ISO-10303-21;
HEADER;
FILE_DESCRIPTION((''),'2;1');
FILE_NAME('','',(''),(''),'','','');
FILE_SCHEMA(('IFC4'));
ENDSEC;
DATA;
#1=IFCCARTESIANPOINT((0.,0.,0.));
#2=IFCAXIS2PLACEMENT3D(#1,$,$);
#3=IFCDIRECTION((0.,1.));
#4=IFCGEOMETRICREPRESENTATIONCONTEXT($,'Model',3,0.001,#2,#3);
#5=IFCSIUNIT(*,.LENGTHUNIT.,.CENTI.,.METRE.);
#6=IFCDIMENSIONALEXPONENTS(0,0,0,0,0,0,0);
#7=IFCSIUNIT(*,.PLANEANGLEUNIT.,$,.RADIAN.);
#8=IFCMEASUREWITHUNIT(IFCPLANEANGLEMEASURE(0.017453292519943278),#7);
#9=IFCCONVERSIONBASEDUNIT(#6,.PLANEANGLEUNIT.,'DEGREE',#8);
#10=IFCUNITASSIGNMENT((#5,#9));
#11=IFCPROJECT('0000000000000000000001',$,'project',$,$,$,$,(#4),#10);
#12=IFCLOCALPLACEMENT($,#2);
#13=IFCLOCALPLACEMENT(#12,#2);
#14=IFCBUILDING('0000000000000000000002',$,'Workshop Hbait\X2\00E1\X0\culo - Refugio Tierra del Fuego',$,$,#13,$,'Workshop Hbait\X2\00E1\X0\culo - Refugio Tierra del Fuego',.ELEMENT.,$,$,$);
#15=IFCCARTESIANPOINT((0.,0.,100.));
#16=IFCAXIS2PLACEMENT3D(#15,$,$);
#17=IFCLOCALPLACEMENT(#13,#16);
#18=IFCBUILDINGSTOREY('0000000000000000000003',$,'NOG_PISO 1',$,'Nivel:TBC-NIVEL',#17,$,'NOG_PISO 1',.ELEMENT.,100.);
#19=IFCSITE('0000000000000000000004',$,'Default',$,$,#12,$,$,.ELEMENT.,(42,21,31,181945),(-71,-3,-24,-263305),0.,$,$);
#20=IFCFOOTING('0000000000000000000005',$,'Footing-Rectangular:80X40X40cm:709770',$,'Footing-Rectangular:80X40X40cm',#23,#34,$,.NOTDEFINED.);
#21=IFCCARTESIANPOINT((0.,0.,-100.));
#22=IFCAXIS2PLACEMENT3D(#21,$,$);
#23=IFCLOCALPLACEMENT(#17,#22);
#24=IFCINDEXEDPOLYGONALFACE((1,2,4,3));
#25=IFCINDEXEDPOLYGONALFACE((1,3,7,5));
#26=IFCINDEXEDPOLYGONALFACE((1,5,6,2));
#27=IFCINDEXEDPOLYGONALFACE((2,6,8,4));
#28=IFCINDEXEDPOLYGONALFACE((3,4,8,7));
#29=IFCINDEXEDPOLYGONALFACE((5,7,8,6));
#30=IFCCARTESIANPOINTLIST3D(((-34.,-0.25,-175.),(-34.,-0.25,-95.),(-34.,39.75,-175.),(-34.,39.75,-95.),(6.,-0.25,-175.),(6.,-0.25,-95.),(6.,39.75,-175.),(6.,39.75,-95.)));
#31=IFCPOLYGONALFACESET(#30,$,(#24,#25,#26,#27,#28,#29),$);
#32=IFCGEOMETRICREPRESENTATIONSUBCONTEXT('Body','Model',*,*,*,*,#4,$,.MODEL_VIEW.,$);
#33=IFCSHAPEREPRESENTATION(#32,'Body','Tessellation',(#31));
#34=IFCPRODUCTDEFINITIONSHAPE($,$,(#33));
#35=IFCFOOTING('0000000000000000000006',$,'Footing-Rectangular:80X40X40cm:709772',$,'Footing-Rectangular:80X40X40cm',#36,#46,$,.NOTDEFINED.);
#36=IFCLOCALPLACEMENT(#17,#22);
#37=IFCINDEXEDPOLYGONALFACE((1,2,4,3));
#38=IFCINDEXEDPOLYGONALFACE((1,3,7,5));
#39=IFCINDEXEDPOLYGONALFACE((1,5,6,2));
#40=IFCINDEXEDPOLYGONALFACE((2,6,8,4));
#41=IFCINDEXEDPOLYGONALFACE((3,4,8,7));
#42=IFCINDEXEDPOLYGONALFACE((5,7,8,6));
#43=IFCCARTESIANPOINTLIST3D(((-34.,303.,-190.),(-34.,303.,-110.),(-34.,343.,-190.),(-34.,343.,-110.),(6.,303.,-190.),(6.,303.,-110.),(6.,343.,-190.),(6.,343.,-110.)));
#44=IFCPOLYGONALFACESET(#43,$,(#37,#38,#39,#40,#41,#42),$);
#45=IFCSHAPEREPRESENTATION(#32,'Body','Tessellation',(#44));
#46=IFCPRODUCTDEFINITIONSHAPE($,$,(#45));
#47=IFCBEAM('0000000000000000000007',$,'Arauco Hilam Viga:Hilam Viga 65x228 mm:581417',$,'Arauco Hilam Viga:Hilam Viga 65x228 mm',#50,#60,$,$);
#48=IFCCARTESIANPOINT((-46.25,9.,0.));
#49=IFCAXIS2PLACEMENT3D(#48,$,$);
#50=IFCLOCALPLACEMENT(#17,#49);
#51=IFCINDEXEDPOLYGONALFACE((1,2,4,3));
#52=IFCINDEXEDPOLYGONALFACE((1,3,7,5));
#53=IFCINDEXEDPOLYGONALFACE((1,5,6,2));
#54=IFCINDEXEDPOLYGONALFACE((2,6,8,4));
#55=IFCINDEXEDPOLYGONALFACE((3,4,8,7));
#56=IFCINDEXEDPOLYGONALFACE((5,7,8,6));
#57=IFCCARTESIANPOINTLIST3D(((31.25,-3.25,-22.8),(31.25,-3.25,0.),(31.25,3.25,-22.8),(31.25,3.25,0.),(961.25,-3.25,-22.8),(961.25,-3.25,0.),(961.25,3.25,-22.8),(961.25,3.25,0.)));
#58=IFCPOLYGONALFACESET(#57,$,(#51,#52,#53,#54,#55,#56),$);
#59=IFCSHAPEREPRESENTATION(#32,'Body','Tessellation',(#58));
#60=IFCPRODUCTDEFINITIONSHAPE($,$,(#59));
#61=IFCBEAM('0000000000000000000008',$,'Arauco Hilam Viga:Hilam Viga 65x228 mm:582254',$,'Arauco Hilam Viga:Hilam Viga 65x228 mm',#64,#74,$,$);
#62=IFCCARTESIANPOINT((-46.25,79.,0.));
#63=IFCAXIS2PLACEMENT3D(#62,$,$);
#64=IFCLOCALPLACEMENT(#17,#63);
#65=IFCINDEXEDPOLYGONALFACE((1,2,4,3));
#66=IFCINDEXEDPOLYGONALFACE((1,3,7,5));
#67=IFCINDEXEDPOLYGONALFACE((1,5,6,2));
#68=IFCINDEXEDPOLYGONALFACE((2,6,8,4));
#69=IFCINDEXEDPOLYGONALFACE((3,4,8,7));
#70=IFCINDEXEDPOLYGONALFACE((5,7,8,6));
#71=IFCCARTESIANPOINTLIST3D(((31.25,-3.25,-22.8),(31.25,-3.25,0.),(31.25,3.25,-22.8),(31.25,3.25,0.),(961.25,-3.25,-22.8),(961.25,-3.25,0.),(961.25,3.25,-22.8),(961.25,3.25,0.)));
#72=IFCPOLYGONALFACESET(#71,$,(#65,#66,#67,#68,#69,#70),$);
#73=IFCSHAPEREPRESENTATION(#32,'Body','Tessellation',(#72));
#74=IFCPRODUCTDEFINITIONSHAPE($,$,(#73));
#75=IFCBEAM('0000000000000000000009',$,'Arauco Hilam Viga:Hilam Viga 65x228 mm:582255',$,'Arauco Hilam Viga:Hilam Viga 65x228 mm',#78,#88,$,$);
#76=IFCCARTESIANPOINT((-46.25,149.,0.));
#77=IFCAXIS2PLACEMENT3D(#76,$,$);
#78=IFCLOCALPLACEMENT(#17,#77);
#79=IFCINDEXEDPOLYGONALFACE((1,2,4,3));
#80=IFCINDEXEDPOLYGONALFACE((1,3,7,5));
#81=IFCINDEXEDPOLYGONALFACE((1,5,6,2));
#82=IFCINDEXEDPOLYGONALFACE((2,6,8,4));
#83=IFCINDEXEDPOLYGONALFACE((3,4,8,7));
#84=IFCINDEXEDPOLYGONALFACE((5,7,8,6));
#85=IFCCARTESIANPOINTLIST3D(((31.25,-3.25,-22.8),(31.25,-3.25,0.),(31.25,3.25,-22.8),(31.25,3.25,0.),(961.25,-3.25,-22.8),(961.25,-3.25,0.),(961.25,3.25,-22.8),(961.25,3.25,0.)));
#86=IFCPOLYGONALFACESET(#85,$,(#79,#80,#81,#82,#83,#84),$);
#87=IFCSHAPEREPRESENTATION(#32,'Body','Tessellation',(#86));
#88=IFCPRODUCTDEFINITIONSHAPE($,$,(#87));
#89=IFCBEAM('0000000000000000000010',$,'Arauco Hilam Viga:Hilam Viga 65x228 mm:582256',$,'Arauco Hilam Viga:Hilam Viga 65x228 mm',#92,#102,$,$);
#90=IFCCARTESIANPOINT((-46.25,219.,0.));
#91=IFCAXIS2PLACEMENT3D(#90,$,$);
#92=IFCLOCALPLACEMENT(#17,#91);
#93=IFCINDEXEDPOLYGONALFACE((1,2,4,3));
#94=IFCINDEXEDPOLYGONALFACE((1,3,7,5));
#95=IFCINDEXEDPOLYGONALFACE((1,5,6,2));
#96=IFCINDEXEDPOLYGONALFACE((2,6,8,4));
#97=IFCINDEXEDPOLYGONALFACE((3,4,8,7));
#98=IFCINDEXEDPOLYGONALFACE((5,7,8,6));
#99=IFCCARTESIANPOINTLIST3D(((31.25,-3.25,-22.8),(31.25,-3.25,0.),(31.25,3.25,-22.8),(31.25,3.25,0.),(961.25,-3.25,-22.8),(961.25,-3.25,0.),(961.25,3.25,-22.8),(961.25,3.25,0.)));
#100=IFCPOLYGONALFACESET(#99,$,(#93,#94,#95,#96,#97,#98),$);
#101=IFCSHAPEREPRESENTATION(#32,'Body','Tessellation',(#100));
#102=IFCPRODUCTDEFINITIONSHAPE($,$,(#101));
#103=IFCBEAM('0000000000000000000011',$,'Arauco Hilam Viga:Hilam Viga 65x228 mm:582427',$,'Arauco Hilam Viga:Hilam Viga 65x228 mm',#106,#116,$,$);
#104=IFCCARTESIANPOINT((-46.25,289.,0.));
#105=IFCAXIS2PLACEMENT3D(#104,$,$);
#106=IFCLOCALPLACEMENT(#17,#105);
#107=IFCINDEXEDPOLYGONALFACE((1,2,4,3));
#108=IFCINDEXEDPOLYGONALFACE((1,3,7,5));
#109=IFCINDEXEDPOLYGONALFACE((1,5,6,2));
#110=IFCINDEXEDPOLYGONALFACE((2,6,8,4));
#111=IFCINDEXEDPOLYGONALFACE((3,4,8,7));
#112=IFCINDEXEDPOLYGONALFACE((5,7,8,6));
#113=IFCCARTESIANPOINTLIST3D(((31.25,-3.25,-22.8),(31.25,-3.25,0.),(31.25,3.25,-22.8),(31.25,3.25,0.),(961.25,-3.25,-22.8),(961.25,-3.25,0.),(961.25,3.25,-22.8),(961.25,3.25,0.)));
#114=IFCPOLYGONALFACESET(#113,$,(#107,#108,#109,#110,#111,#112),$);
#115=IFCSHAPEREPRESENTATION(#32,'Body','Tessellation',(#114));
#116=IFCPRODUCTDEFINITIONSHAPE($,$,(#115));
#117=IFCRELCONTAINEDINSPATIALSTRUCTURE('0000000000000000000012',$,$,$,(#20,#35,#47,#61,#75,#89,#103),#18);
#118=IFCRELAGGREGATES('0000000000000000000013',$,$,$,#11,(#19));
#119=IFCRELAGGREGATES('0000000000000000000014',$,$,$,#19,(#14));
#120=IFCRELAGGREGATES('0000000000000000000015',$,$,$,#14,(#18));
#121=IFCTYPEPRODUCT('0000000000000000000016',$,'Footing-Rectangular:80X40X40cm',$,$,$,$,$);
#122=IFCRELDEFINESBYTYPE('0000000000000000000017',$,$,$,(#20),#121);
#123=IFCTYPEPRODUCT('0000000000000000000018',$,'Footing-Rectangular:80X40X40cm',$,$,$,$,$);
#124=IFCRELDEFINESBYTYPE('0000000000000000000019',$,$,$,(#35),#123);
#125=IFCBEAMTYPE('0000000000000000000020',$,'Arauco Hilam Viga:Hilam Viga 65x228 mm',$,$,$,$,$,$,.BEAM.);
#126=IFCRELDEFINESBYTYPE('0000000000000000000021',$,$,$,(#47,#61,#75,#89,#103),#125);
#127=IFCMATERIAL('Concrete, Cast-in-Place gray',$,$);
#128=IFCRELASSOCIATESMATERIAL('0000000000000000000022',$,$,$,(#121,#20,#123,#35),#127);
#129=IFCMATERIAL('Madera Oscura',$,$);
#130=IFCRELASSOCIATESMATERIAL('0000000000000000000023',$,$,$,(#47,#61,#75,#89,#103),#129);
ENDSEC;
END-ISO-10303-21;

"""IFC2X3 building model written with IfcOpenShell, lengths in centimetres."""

from ifc_helpers import new_model, entity, si_unit, converted_unit, direction, frame, frame_2d, origin, origin_2d_with_axis, place, context, subcontext, project, spatial, rectangle, extrude, source, transform, mapped, material, type_object, type_shapes, element, save


model = new_model("IFC2X3")

# Units and contexts
model_context = context("Model", 3, precision=0.001, world=origin(), true_north=direction((0.0, 1.0)))
body_context = subcontext(model_context, "Body", "Model", "MODEL_VIEW")
ifc_project = project(units=[si_unit("LENGTHUNIT", "METRE", prefix="CENTI"), converted_unit("PLANEANGLEUNIT", "DEGREE", entity("IfcPlaneAngleMeasure", 0.017453292519943278), si_unit("PLANEANGLEUNIT", "RADIAN"), dimensions=[0, 0, 0, 0, 0, 0, 0])], contexts=[model_context])

# Site, building, storey
site_placement = place(None, origin())
site = spatial("IfcSite", under=ifc_project, at=site_placement, Name="Default", CompositionType="ELEMENT", RefLatitude=(42, 21, 31, 181945), RefLongitude=(-71, -3, -24, -263305), RefElevation=0.0)
building_placement = place(site_placement, origin())
building = spatial("IfcBuilding", under=site, at=building_placement, Name="Workshop Hbaitáculo - Refugio Tierra del Fuego", LongName="Workshop Hbaitáculo - Refugio Tierra del Fuego", CompositionType="ELEMENT")
storey_placement = place(building_placement, frame((0.0, 0.0, 100.0)))
storey = spatial("IfcBuildingStorey", under=building, at=storey_placement, Name="NOG_PISO 1", ObjectType="Nivel:TBC-NIVEL", LongName="NOG_PISO 1", CompositionType="ELEMENT", Elevation=100.0)

# Footings
ifc_material_1 = material(Name="Concrete, Cast-in-Place gray")
type_product_1 = type_object("IfcTypeProduct", Name="Footing-Rectangular:80X40X40cm", material=ifc_material_1)
shared_shape_1 = source(origin(), body_context, "Body", "SweptSolid", [
    extrude(rectangle(XDim=40.0, YDim=40.0, at=frame_2d((0.0, 0.0), x_axis=(1.0, 0.0))), frame((-14.0, 19.75, -175.0), z_axis=(0.0, 0.0, 1.0), x_axis=(-1.0, 0.0, 0.0)), (0.0, 0.0, 1.0), 80.0),
])
type_shapes(type_product_1, [shared_shape_1])
footing_1_placement = place(storey_placement, frame((0.0, 0.0, -100.0)))
element("IfcFooting", 1, at=footing_1_placement, inside=storey, type_object=type_product_1, material=ifc_material_1, Name="Footing-Rectangular:80X40X40cm:709770", ObjectType="Footing-Rectangular:80X40X40cm", PredefinedType="NOTDEFINED", context=body_context, shape_type="MappedRepresentation", body=[
    mapped(shared_shape_1, transform((0.0, 0.0, 0.0), scale=1.0)),
])
type_product_2 = type_object("IfcTypeProduct", Name="Footing-Rectangular:80X40X40cm", material=ifc_material_1)
shared_shape_2 = source(origin(), body_context, "Body", "SweptSolid", [
    extrude(rectangle(XDim=40.0, YDim=40.0, at=frame_2d((0.0, 0.0), x_axis=(1.0, 0.0))), frame((-14.0, 323.0, -190.0), z_axis=(0.0, 0.0, 1.0), x_axis=(-1.0, 0.0, 0.0)), (0.0, 0.0, 1.0), 80.0),
])
type_shapes(type_product_2, [shared_shape_2])
footing_2_placement = place(storey_placement, frame((0.0, 0.0, -100.0)))
element("IfcFooting", 2, at=footing_2_placement, inside=storey, type_object=type_product_2, material=ifc_material_1, Name="Footing-Rectangular:80X40X40cm:709772", ObjectType="Footing-Rectangular:80X40X40cm", PredefinedType="NOTDEFINED", context=body_context, shape_type="MappedRepresentation", body=[
    mapped(shared_shape_2, transform((0.0, 0.0, 0.0), scale=1.0)),
])

# Beams
ifc_material_2 = material(Name="Madera Oscura")
beam_type = type_object("IfcBeamType", Name="Arauco Hilam Viga:Hilam Viga 65x228 mm", PredefinedType="BEAM")
beam_1_placement = place(storey_placement, frame((-46.25, 9.0, 0.0)))
element("IfcBeam", 3, at=beam_1_placement, inside=storey, type_object=beam_type, material=ifc_material_2, Name="Arauco Hilam Viga:Hilam Viga 65x228 mm:581417", ObjectType="Arauco Hilam Viga:Hilam Viga 65x228 mm", context=body_context, shape_type="SweptSolid", body=[
    extrude(rectangle(XDim=22.8, YDim=6.5, at=origin_2d_with_axis()), frame((31.25, 0.0, -11.4), z_axis=(1.0, 0.0, 0.0), x_axis=(0.0, 0.0, -1.0)), (0.0, 0.0, 1.0), 930.0),
])
beam_2_placement = place(storey_placement, frame((-46.25, 79.0, 0.0)))
element("IfcBeam", 4, at=beam_2_placement, inside=storey, type_object=beam_type, material=ifc_material_2, Name="Arauco Hilam Viga:Hilam Viga 65x228 mm:582254", ObjectType="Arauco Hilam Viga:Hilam Viga 65x228 mm", context=body_context, shape_type="SweptSolid", body=[
    extrude(rectangle(XDim=22.8, YDim=6.5, at=frame_2d((0.0, 0.0), x_axis=(1.0, 0.0))), frame((31.25, 0.0, -11.4), z_axis=(1.0, 0.0, 0.0), x_axis=(0.0, 0.0, -1.0)), (0.0, 0.0, 1.0), 930.0),
])
beam_3_placement = place(storey_placement, frame((-46.25, 149.0, 0.0)))
element("IfcBeam", 5, at=beam_3_placement, inside=storey, type_object=beam_type, material=ifc_material_2, Name="Arauco Hilam Viga:Hilam Viga 65x228 mm:582255", ObjectType="Arauco Hilam Viga:Hilam Viga 65x228 mm", context=body_context, shape_type="SweptSolid", body=[
    extrude(rectangle(XDim=22.8, YDim=6.5, at=frame_2d((0.0, 0.0), x_axis=(1.0, 0.0))), frame((31.25, 0.0, -11.4), z_axis=(1.0, 0.0, 0.0), x_axis=(0.0, 0.0, -1.0)), (0.0, 0.0, 1.0), 930.0),
])
beam_4_placement = place(storey_placement, frame((-46.25, 219.0, 0.0)))
element("IfcBeam", 6, at=beam_4_placement, inside=storey, type_object=beam_type, material=ifc_material_2, Name="Arauco Hilam Viga:Hilam Viga 65x228 mm:582256", ObjectType="Arauco Hilam Viga:Hilam Viga 65x228 mm", context=body_context, shape_type="SweptSolid", body=[
    extrude(rectangle(XDim=22.8, YDim=6.5, at=frame_2d((0.0, 0.0), x_axis=(1.0, 0.0))), frame((31.25, 0.0, -11.4), z_axis=(1.0, 0.0, 0.0), x_axis=(0.0, 0.0, -1.0)), (0.0, 0.0, 1.0), 930.0),
])
beam_5_placement = place(storey_placement, frame((-46.25, 289.0, 0.0)))
element("IfcBeam", 7, at=beam_5_placement, inside=storey, type_object=beam_type, material=ifc_material_2, Name="Arauco Hilam Viga:Hilam Viga 65x228 mm:582427", ObjectType="Arauco Hilam Viga:Hilam Viga 65x228 mm", context=body_context, shape_type="SweptSolid", body=[
    extrude(rectangle(XDim=22.8, YDim=6.5, at=frame_2d((0.0, 0.0), x_axis=(1.0, 0.0))), frame((31.25, 0.0, -11.4), z_axis=(1.0, 0.0, 0.0), x_axis=(0.0, 0.0, -1.0)), (0.0, 0.0, 1.0), 930.0),
])

save(model, "model.ifc")
